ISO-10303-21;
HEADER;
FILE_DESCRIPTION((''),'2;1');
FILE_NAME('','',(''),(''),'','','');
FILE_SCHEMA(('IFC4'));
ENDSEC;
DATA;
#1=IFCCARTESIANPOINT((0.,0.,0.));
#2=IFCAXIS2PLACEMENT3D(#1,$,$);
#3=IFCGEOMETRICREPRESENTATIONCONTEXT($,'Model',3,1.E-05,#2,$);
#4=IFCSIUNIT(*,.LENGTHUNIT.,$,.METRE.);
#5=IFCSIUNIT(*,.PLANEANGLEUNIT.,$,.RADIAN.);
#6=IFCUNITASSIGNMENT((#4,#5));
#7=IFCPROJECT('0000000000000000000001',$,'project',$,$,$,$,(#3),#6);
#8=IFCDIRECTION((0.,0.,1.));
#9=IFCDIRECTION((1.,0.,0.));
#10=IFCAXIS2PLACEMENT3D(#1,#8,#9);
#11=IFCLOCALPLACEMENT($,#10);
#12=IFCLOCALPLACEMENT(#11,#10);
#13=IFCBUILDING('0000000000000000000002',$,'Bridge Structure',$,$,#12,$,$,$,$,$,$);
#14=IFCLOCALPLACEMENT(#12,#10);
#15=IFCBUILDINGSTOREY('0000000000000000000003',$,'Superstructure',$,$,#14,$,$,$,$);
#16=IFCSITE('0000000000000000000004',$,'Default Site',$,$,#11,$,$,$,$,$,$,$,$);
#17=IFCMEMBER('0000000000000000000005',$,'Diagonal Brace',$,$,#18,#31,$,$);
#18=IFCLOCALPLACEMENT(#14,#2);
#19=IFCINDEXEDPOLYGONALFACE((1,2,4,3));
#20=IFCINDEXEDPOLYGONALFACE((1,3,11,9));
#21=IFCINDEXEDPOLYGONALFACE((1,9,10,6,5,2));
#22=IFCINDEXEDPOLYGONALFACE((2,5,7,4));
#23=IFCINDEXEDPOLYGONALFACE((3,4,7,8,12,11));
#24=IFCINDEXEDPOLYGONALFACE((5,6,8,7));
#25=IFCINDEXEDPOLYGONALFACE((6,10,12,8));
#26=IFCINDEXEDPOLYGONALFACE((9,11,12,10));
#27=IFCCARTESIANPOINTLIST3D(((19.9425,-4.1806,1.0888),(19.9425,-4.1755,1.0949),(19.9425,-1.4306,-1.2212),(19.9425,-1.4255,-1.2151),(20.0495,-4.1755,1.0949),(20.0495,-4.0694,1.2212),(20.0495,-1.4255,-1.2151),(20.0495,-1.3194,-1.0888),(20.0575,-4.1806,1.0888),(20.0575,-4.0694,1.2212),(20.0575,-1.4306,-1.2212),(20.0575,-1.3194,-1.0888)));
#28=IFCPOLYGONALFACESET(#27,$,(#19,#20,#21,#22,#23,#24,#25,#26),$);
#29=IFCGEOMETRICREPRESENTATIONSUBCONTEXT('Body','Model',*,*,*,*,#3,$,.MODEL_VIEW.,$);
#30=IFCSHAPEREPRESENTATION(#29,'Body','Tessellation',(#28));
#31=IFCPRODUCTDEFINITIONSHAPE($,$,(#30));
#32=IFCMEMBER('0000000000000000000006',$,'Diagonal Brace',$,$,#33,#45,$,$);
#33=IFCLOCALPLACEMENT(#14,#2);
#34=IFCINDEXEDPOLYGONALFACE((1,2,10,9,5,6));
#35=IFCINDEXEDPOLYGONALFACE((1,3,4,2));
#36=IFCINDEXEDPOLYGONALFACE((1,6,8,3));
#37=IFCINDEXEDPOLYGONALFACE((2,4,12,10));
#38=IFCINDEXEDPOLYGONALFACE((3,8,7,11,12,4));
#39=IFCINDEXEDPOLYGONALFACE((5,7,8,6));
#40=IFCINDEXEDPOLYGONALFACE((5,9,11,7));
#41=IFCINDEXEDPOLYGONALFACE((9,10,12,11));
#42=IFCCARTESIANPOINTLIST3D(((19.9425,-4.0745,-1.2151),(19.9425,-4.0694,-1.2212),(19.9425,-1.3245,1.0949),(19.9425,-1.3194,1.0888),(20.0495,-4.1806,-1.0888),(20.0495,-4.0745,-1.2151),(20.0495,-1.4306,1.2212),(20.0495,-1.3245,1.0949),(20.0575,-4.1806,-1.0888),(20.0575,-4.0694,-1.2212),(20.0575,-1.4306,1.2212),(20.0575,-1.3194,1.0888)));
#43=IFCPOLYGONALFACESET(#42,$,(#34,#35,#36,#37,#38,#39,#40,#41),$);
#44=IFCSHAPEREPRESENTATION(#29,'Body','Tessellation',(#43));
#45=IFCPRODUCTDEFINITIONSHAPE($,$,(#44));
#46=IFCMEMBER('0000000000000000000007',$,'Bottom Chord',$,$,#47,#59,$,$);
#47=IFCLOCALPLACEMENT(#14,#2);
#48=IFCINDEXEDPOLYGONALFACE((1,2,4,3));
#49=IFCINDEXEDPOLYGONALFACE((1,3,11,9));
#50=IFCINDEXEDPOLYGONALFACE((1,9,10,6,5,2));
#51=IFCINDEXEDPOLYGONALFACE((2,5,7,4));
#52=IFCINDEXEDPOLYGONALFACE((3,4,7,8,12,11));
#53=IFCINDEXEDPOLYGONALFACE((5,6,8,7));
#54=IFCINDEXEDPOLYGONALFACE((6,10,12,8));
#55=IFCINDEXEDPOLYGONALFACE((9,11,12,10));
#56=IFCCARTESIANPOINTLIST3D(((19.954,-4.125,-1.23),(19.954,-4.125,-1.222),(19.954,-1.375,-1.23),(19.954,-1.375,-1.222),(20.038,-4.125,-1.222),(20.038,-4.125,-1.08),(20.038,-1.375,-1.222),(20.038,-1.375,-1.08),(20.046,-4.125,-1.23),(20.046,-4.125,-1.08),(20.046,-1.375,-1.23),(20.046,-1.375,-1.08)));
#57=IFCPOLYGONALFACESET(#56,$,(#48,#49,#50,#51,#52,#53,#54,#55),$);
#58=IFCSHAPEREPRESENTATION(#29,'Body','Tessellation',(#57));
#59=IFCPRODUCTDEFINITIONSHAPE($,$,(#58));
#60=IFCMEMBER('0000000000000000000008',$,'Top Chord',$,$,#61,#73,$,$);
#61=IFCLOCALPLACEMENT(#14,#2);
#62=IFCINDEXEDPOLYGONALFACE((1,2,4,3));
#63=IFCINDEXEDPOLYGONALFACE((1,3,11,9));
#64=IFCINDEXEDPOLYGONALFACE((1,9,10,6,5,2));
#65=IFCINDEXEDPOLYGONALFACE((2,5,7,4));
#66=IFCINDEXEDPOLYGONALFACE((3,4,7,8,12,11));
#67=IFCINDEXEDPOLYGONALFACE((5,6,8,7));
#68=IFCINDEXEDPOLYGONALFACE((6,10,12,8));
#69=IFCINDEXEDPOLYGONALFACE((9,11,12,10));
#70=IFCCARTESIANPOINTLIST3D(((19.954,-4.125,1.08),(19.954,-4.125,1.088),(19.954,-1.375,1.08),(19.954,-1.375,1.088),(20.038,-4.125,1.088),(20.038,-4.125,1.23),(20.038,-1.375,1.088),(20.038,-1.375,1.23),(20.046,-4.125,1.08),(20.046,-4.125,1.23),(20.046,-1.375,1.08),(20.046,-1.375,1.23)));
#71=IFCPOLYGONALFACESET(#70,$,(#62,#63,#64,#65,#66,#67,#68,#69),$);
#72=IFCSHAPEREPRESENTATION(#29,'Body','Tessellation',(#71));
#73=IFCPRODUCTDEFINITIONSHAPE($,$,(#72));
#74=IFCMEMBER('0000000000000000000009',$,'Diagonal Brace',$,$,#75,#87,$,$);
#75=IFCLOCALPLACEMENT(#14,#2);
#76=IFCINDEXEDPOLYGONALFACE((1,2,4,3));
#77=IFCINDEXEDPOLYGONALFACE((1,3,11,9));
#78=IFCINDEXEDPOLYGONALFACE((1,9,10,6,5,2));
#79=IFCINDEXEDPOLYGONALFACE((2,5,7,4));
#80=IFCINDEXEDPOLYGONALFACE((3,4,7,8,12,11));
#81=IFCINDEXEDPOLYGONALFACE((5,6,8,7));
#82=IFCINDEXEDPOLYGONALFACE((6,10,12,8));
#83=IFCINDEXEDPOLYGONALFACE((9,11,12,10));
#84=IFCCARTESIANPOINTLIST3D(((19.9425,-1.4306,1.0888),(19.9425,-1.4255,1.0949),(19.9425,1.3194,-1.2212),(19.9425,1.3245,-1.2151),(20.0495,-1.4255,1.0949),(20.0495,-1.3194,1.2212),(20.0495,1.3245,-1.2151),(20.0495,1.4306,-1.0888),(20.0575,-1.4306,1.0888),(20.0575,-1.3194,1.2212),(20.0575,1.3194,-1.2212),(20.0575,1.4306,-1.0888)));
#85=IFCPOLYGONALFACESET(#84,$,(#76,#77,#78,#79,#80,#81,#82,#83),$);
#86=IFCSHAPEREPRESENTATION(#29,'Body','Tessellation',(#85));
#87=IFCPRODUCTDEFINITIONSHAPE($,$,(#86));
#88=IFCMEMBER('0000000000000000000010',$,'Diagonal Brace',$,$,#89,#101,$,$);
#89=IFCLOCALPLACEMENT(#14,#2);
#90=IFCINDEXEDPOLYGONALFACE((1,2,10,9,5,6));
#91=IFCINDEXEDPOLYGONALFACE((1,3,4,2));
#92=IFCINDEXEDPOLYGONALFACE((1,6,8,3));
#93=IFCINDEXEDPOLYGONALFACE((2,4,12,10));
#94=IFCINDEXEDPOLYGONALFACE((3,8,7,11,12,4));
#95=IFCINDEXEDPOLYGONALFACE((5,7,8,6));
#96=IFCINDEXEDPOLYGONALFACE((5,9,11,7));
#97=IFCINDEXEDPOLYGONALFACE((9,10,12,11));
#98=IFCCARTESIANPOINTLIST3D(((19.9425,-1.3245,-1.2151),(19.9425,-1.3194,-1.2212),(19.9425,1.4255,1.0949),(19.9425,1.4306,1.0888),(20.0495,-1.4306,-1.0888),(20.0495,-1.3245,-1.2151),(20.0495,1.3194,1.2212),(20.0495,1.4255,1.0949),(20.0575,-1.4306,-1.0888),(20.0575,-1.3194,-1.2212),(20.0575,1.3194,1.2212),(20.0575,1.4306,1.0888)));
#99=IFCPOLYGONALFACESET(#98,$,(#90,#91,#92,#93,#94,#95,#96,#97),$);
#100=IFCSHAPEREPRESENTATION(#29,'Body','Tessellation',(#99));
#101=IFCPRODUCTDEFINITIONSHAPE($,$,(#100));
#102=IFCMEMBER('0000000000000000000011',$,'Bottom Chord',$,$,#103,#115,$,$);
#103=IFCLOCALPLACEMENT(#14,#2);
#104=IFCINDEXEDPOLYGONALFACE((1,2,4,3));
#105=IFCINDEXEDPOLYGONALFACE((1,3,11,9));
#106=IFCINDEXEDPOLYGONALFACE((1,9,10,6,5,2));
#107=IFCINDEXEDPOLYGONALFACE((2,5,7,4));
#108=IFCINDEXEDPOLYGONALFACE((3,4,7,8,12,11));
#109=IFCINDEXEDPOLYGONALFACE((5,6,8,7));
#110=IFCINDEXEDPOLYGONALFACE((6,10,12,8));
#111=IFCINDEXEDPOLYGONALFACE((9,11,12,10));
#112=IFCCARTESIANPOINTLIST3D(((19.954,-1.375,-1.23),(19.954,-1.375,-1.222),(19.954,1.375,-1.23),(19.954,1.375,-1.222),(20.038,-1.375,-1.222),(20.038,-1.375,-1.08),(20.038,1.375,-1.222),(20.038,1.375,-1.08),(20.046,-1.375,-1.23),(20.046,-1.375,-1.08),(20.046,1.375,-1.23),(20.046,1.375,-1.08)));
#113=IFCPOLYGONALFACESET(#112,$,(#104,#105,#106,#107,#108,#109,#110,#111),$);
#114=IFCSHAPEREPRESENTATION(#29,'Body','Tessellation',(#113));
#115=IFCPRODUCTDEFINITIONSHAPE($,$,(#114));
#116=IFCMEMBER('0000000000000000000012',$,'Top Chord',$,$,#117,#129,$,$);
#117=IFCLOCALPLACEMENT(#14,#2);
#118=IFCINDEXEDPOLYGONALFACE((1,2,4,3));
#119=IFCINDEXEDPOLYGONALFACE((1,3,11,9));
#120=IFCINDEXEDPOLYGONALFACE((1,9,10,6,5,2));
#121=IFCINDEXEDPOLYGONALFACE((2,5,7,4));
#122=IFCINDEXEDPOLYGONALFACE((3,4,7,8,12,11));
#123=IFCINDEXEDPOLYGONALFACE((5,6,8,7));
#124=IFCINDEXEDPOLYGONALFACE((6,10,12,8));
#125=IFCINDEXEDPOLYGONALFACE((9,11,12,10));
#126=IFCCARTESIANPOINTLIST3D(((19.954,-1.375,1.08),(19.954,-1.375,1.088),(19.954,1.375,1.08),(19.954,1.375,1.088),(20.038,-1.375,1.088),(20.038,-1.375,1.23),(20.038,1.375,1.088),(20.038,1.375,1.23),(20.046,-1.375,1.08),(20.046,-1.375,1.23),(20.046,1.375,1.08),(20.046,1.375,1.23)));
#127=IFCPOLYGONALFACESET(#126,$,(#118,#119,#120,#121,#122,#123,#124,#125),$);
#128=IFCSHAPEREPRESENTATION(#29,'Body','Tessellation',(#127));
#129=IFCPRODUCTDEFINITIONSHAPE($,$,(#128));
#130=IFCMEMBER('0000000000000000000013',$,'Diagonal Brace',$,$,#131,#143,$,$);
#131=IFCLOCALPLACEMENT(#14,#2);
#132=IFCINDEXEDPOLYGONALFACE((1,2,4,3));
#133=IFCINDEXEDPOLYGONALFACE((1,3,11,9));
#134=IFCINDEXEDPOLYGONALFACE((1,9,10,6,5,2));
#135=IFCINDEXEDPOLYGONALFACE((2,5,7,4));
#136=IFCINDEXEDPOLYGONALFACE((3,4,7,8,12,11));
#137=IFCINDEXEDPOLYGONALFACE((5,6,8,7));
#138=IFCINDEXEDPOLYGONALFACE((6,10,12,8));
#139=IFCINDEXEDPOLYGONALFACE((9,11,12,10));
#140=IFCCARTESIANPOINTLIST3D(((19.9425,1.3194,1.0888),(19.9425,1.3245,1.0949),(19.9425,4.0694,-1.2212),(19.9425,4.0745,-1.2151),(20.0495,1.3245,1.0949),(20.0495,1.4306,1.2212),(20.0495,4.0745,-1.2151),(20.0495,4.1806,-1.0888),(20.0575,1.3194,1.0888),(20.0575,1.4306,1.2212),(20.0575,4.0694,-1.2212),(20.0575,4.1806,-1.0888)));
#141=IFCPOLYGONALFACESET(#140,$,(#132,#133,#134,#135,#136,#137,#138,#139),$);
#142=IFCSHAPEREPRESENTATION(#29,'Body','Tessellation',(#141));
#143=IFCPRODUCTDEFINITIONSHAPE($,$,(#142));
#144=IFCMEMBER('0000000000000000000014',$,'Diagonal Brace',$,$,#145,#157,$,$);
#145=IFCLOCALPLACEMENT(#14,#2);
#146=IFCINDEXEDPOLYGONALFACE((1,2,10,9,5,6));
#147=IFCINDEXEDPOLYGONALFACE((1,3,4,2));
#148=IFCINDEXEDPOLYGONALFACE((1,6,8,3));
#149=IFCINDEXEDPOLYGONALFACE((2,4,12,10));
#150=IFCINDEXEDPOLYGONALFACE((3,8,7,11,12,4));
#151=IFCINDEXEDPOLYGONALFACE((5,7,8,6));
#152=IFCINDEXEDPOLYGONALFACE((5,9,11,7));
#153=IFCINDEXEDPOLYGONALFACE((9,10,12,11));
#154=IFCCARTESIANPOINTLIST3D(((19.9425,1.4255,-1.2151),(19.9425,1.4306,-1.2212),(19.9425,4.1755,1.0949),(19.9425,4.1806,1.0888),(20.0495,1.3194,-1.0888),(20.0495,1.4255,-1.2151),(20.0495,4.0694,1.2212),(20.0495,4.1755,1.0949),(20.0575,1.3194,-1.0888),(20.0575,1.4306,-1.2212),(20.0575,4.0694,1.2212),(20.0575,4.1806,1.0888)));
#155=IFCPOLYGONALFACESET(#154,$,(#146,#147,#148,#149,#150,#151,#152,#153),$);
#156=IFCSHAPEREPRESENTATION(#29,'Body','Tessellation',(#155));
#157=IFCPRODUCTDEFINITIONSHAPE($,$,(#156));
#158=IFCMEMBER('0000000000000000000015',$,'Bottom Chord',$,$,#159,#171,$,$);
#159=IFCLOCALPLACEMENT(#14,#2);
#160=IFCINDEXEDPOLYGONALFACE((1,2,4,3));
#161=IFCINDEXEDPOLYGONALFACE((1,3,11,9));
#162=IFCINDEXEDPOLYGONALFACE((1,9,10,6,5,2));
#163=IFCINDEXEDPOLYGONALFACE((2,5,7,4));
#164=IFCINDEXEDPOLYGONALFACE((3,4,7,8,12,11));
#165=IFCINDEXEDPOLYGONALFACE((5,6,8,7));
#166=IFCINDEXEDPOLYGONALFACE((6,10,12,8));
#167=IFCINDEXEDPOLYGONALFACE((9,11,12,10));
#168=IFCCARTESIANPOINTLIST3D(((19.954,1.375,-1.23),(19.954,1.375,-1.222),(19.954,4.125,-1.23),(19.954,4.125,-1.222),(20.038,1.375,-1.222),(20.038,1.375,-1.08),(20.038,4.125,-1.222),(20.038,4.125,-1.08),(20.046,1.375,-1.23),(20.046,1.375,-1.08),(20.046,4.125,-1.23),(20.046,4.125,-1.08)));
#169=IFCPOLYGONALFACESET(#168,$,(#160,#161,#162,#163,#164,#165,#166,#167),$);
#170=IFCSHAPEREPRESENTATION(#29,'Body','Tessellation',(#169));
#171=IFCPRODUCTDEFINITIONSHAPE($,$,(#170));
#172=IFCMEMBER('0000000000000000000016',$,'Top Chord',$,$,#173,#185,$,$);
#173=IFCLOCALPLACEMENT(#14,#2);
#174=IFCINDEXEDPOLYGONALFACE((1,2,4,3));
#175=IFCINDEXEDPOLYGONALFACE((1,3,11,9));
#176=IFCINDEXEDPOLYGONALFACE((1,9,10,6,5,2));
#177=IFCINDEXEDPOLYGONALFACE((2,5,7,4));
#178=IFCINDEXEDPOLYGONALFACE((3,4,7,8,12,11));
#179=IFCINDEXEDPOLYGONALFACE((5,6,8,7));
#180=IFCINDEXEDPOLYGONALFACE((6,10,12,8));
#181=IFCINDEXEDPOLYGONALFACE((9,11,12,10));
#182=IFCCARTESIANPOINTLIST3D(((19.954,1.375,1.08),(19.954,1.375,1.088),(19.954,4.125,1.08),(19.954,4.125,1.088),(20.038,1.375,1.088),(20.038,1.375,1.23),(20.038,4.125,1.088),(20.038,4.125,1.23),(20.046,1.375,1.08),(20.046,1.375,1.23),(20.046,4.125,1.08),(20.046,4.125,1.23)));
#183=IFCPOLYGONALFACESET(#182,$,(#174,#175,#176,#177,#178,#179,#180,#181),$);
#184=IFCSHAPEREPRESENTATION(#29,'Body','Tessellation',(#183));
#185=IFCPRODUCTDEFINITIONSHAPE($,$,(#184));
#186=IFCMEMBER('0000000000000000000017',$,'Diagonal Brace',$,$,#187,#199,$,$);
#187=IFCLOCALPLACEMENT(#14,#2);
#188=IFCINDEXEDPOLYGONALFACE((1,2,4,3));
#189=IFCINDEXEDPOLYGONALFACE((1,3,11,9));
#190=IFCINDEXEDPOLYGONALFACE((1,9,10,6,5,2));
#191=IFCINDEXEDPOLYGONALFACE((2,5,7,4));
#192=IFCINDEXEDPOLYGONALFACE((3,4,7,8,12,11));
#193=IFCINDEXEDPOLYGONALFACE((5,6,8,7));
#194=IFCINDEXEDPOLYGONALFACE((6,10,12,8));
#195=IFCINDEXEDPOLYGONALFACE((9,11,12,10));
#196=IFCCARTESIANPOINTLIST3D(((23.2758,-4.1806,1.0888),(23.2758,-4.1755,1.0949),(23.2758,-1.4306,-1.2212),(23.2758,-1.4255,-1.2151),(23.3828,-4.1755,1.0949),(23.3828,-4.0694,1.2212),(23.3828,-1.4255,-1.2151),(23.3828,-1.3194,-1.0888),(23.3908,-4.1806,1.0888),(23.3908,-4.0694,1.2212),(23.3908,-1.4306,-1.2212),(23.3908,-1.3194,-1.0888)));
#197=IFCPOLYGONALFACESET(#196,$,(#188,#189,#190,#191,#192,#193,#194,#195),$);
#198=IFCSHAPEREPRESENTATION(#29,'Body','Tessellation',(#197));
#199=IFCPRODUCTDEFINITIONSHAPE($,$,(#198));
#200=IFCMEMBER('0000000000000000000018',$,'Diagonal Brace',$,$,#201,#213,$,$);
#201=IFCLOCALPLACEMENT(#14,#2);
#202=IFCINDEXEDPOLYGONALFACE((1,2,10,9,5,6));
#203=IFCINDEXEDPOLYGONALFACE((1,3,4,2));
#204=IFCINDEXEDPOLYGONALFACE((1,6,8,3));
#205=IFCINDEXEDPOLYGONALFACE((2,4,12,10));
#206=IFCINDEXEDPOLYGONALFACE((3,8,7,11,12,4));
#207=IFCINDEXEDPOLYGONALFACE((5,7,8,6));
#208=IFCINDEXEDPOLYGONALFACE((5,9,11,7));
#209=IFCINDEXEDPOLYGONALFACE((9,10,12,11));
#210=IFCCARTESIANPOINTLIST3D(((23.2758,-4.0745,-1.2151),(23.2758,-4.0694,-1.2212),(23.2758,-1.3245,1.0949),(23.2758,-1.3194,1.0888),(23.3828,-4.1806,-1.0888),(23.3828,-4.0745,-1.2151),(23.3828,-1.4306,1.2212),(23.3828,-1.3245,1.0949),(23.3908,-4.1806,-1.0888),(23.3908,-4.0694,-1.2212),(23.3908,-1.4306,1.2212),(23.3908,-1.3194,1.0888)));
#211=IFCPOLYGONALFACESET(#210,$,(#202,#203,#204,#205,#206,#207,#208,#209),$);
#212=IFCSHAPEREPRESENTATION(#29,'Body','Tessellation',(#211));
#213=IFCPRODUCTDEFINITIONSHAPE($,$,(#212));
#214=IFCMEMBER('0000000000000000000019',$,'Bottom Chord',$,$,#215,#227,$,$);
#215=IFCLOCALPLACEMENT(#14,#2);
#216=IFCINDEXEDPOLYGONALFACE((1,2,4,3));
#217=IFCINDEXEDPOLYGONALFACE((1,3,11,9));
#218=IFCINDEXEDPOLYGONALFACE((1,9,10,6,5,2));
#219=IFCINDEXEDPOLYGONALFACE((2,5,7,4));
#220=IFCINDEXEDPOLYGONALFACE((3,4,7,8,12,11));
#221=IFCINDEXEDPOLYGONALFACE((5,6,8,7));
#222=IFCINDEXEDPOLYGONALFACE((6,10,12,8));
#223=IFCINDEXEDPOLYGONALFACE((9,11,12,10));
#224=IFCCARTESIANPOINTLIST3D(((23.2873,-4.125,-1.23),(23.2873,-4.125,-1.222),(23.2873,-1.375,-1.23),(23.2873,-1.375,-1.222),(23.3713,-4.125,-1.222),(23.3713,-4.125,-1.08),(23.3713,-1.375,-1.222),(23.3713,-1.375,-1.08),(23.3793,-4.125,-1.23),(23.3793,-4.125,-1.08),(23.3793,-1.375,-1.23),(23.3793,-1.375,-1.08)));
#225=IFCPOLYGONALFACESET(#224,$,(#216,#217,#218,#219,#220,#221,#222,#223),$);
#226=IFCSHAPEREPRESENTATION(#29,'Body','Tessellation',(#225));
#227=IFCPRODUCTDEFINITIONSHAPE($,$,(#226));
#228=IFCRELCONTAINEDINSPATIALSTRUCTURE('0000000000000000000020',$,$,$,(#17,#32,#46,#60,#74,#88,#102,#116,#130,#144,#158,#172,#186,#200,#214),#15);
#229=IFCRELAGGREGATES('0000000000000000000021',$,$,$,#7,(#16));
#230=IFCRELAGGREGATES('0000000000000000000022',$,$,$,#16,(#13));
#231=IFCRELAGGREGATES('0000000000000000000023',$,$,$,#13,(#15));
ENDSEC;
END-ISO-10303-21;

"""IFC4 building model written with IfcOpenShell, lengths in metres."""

from ifc_helpers import new_model, si_unit, frame, origin, origin_with_axes, origin_2d_with_axis, place, context, subcontext, project, spatial, l_section, extrude, element, save


model = new_model("IFC4")

# Units and contexts
model_context = context("Model", 3, precision=1e-05, world=origin())
body_context = subcontext(model_context, "Body", "Model", "MODEL_VIEW")
ifc_project = project(units=[si_unit("LENGTHUNIT", "METRE"), si_unit("PLANEANGLEUNIT", "RADIAN")], contexts=[model_context])

# Site, building, storey
site_placement = place(None, origin_with_axes())
site = spatial("IfcSite", under=ifc_project, at=site_placement, Name="Default Site")
building_placement = place(site_placement, origin_with_axes())
building = spatial("IfcBuilding", under=site, at=building_placement, Name="Bridge Structure")
storey_placement = place(building_placement, origin_with_axes())
storey = spatial("IfcBuildingStorey", under=building, at=storey_placement, Name="Superstructure")

# Members
for number, where, z_axis, x_axis, name in (
    (1, (20.0, -4.125, 1.155), (0.0, 0.765705, -0.643192), (-1.0, 0.0, 0.0), "Diagonal Brace"),
    (2, (20.0, -4.125, -1.155), (0.0, 0.765705, 0.643192), (-1.0, 0.0, 0.0), "Diagonal Brace"),
):
    element("IfcMember", number, at=place(storey_placement, frame(where, z_axis=z_axis, x_axis=x_axis)), inside=storey, Name=name, context=body_context, shape_type="SweptSolid", body=[
        extrude(l_section(Depth=0.173, Width=0.115, Thickness=0.008, at=origin_2d_with_axis()), origin_with_axes(), (0.0, 0.0, 1.0), 3.5915),
    ])
for number, where, z_axis, x_axis, name in (
    (3, (20.0, -4.125, -1.155), (0.0, 1.0, 0.0), (-1.0, 0.0, 0.0), "Bottom Chord"),
    (4, (20.0, -4.125, 1.155), (0.0, 1.0, 0.0), (-1.0, 0.0, 0.0), "Top Chord"),
):
    element("IfcMember", number, at=place(storey_placement, frame(where, z_axis=z_axis, x_axis=x_axis)), inside=storey, Name=name, context=body_context, shape_type="SweptSolid", body=[
        extrude(l_section(Depth=0.15, Width=0.092, Thickness=0.008, at=origin_2d_with_axis()), origin_with_axes(), (0.0, 0.0, 1.0), 2.75),
    ])
for number, where, z_axis, x_axis, name in (
    (5, (20.0, -1.375, 1.155), (0.0, 0.765705, -0.643192), (-1.0, 0.0, 0.0), "Diagonal Brace"),
    (6, (20.0, -1.375, -1.155), (0.0, 0.765705, 0.643192), (-1.0, 0.0, 0.0), "Diagonal Brace"),
):
    element("IfcMember", number, at=place(storey_placement, frame(where, z_axis=z_axis, x_axis=x_axis)), inside=storey, Name=name, context=body_context, shape_type="SweptSolid", body=[
        extrude(l_section(Depth=0.173, Width=0.115, Thickness=0.008, at=origin_2d_with_axis()), origin_with_axes(), (0.0, 0.0, 1.0), 3.5915),
    ])
for number, where, z_axis, x_axis, name in (
    (7, (20.0, -1.375, -1.155), (0.0, 1.0, 0.0), (-1.0, 0.0, 0.0), "Bottom Chord"),
    (8, (20.0, -1.375, 1.155), (0.0, 1.0, 0.0), (-1.0, 0.0, 0.0), "Top Chord"),
):
    element("IfcMember", number, at=place(storey_placement, frame(where, z_axis=z_axis, x_axis=x_axis)), inside=storey, Name=name, context=body_context, shape_type="SweptSolid", body=[
        extrude(l_section(Depth=0.15, Width=0.092, Thickness=0.008, at=origin_2d_with_axis()), origin_with_axes(), (0.0, 0.0, 1.0), 2.75),
    ])
for number, where, z_axis, x_axis, name in (
    (9, (20.0, 1.375, 1.155), (0.0, 0.765705, -0.643192), (-1.0, 0.0, 0.0), "Diagonal Brace"),
    (10, (20.0, 1.375, -1.155), (0.0, 0.765705, 0.643192), (-1.0, 0.0, 0.0), "Diagonal Brace"),
):
    element("IfcMember", number, at=place(storey_placement, frame(where, z_axis=z_axis, x_axis=x_axis)), inside=storey, Name=name, context=body_context, shape_type="SweptSolid", body=[
        extrude(l_section(Depth=0.173, Width=0.115, Thickness=0.008, at=origin_2d_with_axis()), origin_with_axes(), (0.0, 0.0, 1.0), 3.5915),
    ])
for number, where, z_axis, x_axis, name in (
    (11, (20.0, 1.375, -1.155), (0.0, 1.0, 0.0), (-1.0, 0.0, 0.0), "Bottom Chord"),
    (12, (20.0, 1.375, 1.155), (0.0, 1.0, 0.0), (-1.0, 0.0, 0.0), "Top Chord"),
):
    element("IfcMember", number, at=place(storey_placement, frame(where, z_axis=z_axis, x_axis=x_axis)), inside=storey, Name=name, context=body_context, shape_type="SweptSolid", body=[
        extrude(l_section(Depth=0.15, Width=0.092, Thickness=0.008, at=origin_2d_with_axis()), origin_with_axes(), (0.0, 0.0, 1.0), 2.75),
    ])
for number, where, z_axis, x_axis, name in (
    (13, (23.3333, -4.125, 1.155), (0.0, 0.765705, -0.643192), (-1.0, 0.0, 0.0), "Diagonal Brace"),
    (14, (23.3333, -4.125, -1.155), (0.0, 0.765705, 0.643192), (-1.0, 0.0, 0.0), "Diagonal Brace"),
):
    element("IfcMember", number, at=place(storey_placement, frame(where, z_axis=z_axis, x_axis=x_axis)), inside=storey, Name=name, context=body_context, shape_type="SweptSolid", body=[
        extrude(l_section(Depth=0.173, Width=0.115, Thickness=0.008, at=origin_2d_with_axis()), origin_with_axes(), (0.0, 0.0, 1.0), 3.5915),
    ])
for number, where, z_axis, x_axis, name in (
    (15, (23.3333, -4.125, -1.155), (0.0, 1.0, 0.0), (-1.0, 0.0, 0.0), "Bottom Chord"),
):
    element("IfcMember", number, at=place(storey_placement, frame(where, z_axis=z_axis, x_axis=x_axis)), inside=storey, Name=name, context=body_context, shape_type="SweptSolid", body=[
        extrude(l_section(Depth=0.15, Width=0.092, Thickness=0.008, at=origin_2d_with_axis()), origin_with_axes(), (0.0, 0.0, 1.0), 2.75),
    ])

save(model, "model.ifc")
